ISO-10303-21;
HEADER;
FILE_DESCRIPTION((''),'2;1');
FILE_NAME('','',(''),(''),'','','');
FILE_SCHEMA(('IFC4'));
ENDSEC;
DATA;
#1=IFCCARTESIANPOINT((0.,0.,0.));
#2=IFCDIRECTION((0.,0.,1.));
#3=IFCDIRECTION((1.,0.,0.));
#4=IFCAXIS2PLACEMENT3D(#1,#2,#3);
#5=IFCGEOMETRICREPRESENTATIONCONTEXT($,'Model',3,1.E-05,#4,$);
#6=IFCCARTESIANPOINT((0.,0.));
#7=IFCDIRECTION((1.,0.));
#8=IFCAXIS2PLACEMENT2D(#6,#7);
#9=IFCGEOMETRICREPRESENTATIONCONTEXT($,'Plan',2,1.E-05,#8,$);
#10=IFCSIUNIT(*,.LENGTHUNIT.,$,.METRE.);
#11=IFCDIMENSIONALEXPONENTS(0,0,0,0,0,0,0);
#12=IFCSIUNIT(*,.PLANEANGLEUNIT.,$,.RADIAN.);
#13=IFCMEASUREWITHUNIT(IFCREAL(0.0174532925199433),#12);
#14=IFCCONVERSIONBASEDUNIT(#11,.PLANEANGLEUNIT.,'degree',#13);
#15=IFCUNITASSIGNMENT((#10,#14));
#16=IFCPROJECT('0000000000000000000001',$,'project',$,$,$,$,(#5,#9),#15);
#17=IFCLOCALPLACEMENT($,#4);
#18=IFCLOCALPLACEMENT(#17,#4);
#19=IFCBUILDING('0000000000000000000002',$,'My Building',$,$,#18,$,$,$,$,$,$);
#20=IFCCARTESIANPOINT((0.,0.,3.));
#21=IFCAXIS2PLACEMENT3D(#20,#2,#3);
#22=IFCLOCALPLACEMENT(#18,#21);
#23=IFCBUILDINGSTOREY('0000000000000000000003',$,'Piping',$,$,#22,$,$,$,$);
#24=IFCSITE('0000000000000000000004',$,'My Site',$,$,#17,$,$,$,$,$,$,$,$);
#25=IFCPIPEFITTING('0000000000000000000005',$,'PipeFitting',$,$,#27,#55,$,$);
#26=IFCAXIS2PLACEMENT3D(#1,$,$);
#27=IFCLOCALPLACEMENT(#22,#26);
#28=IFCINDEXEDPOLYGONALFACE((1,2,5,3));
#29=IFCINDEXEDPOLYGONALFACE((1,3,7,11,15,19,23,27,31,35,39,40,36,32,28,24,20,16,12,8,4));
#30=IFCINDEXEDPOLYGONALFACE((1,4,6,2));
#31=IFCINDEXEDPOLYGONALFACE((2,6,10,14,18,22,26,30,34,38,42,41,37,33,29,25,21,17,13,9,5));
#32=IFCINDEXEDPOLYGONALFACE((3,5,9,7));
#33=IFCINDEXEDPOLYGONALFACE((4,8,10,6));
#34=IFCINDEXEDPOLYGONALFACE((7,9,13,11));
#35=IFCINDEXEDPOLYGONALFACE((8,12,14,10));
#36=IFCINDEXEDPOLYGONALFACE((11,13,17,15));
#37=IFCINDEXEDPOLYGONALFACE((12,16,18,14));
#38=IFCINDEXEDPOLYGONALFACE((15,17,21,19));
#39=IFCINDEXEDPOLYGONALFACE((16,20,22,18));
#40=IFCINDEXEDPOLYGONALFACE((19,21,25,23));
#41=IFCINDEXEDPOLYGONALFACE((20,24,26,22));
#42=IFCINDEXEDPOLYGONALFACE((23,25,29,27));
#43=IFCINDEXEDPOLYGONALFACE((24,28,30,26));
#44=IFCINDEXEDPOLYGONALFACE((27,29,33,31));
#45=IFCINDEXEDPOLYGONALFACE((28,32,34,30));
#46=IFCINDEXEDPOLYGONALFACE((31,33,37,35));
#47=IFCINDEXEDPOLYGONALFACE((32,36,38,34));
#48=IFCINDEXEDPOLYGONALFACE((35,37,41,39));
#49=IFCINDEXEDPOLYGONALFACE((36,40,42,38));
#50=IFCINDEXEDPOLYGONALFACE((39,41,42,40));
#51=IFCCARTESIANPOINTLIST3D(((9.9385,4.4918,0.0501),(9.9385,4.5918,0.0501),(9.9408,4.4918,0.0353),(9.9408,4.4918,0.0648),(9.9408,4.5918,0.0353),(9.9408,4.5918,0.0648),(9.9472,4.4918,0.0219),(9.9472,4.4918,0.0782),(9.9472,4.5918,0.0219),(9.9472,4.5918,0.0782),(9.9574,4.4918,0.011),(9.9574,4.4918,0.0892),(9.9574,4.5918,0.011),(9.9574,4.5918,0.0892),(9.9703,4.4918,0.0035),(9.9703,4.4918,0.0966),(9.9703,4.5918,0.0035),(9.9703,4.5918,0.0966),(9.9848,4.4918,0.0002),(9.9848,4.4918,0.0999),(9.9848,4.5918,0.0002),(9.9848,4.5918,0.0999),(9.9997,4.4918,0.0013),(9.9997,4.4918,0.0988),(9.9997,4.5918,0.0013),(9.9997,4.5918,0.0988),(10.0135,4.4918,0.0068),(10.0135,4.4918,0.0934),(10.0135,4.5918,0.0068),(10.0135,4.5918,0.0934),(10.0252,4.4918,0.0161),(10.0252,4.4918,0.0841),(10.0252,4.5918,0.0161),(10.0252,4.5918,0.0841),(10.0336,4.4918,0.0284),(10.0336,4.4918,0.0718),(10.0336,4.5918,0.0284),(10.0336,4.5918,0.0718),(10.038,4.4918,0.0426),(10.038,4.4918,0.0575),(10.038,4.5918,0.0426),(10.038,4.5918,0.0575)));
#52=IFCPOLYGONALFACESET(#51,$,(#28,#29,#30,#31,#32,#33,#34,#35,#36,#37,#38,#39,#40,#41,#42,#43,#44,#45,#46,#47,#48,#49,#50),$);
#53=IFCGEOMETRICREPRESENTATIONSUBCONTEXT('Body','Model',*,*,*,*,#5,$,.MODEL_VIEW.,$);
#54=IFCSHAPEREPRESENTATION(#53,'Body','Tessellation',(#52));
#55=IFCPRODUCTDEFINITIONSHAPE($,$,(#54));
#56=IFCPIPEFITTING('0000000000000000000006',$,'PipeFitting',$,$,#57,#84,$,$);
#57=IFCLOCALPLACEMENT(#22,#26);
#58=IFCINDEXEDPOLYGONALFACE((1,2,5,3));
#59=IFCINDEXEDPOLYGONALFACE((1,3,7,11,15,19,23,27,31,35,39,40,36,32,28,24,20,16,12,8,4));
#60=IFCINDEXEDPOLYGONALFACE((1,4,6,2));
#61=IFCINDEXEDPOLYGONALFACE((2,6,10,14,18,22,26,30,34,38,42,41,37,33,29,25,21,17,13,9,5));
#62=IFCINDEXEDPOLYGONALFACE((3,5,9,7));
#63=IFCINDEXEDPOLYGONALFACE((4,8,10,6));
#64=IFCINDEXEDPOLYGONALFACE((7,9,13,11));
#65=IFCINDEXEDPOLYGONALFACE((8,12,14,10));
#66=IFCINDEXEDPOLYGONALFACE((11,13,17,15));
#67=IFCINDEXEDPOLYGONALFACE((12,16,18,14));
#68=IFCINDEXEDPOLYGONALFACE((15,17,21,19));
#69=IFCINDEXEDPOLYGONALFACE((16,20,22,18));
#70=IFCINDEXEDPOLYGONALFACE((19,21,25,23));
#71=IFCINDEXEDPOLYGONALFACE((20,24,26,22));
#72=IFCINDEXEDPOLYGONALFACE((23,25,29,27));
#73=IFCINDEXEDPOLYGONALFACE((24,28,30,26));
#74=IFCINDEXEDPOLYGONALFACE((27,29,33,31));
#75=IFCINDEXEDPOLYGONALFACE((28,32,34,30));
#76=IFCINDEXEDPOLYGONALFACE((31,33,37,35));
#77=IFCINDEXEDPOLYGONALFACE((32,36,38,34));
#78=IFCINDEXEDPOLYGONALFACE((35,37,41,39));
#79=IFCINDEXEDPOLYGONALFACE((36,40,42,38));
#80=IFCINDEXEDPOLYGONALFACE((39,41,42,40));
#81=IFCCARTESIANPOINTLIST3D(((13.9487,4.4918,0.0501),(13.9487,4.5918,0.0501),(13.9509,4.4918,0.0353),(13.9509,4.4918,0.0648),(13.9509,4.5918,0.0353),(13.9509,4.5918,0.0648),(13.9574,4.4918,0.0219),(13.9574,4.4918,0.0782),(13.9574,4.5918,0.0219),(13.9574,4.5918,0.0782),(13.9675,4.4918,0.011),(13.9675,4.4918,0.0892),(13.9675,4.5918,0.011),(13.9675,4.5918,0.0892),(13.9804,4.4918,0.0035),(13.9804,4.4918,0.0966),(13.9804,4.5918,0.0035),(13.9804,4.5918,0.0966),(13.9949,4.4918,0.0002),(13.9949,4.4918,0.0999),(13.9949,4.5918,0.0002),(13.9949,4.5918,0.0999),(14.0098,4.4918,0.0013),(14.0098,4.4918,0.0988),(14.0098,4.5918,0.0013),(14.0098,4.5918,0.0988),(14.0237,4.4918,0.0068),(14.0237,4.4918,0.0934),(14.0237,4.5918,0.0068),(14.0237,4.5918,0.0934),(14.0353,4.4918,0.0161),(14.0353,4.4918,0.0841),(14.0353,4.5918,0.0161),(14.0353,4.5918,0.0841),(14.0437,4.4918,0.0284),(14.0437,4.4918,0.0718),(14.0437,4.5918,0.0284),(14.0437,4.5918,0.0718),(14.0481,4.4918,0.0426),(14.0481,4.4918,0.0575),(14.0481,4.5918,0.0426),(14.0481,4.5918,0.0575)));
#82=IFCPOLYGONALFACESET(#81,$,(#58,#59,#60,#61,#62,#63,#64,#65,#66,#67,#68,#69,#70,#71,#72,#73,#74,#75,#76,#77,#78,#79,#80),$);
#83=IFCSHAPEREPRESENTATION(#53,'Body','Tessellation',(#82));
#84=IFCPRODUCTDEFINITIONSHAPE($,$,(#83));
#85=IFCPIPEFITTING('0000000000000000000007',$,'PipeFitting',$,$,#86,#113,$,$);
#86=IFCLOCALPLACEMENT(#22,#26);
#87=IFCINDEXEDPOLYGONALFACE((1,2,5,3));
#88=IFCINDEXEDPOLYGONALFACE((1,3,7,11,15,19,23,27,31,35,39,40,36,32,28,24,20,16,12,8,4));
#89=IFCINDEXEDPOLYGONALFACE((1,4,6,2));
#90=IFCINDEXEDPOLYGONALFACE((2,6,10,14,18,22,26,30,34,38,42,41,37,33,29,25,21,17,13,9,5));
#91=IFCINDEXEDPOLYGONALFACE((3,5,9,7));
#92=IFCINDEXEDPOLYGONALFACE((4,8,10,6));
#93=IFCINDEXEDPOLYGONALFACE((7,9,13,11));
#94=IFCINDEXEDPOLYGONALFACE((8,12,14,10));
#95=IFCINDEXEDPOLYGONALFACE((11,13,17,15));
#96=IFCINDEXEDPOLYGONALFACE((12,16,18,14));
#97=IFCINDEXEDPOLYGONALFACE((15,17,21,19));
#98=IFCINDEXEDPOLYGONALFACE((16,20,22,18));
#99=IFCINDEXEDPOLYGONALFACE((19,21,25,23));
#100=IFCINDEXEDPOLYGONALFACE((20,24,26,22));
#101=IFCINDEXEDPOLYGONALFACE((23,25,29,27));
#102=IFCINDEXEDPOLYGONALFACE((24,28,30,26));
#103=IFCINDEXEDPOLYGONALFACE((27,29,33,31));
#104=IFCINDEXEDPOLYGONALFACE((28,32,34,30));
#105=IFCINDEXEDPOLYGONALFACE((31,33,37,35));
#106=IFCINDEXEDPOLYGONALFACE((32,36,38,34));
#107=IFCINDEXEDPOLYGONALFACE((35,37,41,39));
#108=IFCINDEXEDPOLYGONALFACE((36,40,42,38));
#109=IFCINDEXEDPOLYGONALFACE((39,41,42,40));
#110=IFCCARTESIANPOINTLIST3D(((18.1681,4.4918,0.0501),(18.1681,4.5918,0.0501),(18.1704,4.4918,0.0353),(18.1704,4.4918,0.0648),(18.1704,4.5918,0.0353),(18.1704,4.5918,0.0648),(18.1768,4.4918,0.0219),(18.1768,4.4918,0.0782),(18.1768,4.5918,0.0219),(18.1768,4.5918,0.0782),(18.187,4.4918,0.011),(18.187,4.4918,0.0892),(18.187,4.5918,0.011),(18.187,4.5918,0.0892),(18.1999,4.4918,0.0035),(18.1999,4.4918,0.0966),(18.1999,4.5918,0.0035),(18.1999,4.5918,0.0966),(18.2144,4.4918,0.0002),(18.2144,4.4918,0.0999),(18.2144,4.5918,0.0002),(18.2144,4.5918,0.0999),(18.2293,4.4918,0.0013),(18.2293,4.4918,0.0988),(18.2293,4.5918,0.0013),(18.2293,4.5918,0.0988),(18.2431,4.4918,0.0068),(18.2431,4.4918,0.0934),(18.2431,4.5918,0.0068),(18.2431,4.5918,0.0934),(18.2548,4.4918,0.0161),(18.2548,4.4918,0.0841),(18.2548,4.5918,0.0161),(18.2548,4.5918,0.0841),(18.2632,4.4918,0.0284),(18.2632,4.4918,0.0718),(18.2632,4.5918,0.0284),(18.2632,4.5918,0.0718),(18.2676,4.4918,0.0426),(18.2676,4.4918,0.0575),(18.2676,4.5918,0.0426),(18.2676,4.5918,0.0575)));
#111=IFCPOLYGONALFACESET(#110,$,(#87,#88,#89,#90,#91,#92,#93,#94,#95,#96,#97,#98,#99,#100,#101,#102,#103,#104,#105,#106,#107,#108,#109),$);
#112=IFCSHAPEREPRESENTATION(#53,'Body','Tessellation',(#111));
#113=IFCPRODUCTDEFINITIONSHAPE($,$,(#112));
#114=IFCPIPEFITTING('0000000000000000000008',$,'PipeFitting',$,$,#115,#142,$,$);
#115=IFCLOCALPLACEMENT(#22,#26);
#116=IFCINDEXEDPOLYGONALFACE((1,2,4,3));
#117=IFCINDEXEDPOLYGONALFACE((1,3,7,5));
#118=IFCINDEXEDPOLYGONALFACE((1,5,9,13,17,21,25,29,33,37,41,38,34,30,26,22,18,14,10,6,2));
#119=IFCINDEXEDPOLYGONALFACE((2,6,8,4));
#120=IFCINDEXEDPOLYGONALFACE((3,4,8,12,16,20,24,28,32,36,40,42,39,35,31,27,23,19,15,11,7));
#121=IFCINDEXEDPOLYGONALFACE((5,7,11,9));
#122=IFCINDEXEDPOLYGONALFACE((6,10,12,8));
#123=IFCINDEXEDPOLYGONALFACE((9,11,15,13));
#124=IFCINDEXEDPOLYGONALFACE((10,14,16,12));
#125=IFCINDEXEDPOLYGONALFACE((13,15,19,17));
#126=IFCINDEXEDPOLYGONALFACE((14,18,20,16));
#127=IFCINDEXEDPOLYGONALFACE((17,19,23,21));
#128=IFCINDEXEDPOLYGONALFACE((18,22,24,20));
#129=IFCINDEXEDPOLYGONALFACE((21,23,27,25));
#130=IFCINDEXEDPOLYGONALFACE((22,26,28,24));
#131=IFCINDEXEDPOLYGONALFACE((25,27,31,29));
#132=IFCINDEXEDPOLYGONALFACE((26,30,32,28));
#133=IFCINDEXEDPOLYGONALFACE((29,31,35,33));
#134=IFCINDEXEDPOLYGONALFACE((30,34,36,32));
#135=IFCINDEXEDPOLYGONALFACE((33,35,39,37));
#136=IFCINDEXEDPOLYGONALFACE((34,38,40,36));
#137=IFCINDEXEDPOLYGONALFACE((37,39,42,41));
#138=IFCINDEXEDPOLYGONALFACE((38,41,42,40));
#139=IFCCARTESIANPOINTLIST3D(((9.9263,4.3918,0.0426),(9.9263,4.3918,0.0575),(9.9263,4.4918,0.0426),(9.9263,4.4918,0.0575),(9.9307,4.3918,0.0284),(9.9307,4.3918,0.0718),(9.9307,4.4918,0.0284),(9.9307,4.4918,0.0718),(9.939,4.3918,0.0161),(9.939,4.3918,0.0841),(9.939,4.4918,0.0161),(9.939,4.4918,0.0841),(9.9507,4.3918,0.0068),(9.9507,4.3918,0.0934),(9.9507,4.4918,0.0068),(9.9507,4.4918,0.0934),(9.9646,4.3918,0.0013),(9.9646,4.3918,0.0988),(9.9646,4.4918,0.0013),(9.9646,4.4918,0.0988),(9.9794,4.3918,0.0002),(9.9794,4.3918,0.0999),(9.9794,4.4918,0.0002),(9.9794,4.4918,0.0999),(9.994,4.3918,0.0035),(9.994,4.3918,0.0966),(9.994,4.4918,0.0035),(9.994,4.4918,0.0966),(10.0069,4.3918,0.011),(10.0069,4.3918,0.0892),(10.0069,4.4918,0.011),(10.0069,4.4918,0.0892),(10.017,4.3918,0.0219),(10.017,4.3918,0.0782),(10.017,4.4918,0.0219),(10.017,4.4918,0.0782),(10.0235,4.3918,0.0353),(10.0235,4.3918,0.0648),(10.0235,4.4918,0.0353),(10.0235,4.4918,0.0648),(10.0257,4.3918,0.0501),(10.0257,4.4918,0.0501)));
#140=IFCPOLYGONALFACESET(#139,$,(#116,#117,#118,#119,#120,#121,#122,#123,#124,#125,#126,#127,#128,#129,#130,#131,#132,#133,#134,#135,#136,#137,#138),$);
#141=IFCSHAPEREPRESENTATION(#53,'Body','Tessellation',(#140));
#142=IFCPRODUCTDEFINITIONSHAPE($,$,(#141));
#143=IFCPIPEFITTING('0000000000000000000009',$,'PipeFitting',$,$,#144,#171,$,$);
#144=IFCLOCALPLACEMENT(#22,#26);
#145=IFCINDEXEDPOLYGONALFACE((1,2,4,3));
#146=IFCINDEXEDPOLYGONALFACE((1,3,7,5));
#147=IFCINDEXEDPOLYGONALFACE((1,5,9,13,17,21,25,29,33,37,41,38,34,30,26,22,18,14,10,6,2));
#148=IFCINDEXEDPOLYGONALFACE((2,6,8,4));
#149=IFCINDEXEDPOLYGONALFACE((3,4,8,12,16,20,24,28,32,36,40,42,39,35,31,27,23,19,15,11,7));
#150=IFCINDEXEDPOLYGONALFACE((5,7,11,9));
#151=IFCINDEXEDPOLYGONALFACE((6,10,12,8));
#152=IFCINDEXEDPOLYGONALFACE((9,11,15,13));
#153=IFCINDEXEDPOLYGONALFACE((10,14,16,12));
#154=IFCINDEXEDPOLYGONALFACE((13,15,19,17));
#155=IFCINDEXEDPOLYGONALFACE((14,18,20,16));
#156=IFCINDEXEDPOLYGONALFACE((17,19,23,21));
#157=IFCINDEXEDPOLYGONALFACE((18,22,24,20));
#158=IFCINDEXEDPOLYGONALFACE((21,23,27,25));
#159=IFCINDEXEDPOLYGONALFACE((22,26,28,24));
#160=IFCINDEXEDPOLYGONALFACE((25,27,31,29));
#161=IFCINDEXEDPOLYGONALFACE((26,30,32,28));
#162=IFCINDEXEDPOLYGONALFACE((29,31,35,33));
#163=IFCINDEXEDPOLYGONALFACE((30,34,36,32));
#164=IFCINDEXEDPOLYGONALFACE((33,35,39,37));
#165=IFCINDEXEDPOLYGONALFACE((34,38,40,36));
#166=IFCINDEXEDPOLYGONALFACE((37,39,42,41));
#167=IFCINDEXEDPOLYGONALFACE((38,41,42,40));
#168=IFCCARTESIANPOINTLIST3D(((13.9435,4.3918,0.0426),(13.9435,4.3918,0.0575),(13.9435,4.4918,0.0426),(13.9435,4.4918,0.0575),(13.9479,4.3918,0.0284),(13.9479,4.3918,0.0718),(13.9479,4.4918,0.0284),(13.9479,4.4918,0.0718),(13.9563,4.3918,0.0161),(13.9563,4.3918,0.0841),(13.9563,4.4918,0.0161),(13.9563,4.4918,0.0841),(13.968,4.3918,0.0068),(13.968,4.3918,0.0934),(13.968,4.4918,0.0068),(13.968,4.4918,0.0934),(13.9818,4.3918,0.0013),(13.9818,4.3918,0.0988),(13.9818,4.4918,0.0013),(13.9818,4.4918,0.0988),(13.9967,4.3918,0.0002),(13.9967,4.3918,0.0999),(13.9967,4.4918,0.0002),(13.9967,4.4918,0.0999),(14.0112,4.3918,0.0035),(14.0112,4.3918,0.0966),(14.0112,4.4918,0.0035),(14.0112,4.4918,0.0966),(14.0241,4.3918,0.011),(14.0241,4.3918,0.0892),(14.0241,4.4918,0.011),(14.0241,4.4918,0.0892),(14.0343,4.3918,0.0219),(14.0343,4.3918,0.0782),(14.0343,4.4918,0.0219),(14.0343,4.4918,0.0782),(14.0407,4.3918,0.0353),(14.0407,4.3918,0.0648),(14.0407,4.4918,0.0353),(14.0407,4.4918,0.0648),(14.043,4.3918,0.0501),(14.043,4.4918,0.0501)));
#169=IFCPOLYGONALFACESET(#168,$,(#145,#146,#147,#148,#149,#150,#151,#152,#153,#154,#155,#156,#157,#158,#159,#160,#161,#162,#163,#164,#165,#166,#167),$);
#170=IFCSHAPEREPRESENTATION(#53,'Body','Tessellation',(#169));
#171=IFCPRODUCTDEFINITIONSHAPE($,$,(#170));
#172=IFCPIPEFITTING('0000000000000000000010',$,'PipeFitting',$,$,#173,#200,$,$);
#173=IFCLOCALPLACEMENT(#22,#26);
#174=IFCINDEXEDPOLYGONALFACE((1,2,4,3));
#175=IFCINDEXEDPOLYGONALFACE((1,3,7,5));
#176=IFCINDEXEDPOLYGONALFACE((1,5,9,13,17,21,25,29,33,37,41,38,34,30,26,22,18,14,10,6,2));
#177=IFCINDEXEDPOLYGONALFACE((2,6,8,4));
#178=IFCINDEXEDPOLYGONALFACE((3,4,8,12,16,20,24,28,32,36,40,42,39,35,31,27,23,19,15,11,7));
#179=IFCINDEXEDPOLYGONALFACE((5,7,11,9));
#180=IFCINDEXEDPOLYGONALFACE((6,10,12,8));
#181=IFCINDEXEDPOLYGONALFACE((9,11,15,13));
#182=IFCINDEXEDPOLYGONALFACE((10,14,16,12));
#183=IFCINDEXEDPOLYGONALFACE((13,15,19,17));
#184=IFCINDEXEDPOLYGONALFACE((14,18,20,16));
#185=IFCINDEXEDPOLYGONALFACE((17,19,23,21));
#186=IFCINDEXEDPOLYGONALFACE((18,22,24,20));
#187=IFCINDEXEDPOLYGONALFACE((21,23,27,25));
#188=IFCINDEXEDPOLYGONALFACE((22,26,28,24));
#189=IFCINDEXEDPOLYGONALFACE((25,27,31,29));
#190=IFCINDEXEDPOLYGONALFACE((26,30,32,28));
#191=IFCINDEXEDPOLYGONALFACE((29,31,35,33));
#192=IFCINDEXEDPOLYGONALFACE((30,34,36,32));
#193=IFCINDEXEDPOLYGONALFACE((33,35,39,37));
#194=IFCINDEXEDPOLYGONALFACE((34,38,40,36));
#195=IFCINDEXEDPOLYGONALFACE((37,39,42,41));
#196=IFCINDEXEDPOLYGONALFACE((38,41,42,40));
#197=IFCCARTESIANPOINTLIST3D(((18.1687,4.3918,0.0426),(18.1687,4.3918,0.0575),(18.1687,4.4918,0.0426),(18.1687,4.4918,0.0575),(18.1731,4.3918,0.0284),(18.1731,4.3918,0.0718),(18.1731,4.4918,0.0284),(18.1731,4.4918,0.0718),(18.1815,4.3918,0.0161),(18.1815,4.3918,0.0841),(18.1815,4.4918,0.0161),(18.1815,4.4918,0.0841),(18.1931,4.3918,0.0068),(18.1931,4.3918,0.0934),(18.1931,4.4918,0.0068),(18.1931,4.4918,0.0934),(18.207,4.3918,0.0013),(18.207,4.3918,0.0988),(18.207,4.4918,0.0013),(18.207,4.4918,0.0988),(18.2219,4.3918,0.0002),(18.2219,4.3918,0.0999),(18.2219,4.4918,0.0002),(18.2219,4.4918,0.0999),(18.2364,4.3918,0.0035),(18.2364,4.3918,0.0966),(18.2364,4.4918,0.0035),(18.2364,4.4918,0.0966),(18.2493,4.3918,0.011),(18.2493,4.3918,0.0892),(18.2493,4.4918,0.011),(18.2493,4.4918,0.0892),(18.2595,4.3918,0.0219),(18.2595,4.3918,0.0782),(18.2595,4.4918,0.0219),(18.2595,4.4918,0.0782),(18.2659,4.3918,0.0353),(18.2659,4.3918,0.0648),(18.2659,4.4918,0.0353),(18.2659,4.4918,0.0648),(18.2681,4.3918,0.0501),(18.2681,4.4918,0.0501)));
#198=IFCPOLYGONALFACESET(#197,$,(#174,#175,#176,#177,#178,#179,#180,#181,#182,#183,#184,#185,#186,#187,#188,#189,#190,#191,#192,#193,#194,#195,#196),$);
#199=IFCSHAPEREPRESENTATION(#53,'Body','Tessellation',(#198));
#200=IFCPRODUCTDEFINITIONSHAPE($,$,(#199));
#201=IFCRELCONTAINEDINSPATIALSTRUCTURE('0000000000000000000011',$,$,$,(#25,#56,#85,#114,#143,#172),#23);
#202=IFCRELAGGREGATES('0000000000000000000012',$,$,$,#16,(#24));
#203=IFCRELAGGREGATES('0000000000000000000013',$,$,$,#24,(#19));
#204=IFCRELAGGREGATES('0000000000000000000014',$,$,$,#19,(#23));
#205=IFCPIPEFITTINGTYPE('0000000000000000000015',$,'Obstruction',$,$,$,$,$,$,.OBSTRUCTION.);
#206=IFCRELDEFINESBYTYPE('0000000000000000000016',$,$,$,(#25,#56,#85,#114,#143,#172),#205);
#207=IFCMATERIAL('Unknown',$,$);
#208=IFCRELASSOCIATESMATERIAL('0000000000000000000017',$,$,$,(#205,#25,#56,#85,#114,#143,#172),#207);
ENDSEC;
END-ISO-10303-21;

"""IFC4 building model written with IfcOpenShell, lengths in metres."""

from ifc_helpers import new_model, entity, si_unit, converted_unit, frame, origin_with_axes, origin_2d_with_axis, place, context, subcontext, project, spatial, circle, extrude, material, material_profile, profile_set, profile_usage, type_object, element, save


model = new_model("IFC4")

# Units and contexts
model_context = context("Model", 3, precision=1e-05, world=origin_with_axes())
plan_context = context("Plan", 2, precision=1e-05, world=origin_2d_with_axis())
body_context = subcontext(model_context, "Body", "Model", "MODEL_VIEW")
ifc_project = project(units=[si_unit("LENGTHUNIT", "METRE"), converted_unit("PLANEANGLEUNIT", "degree", entity("IfcReal", 0.0174532925199433), si_unit("PLANEANGLEUNIT", "RADIAN"), dimensions=[0, 0, 0, 0, 0, 0, 0])], contexts=[model_context, plan_context])

# Site, building, storey
site_placement = place(None, origin_with_axes())
site = spatial("IfcSite", under=ifc_project, at=site_placement, Name="My Site")
building_placement = place(site_placement, origin_with_axes())
building = spatial("IfcBuilding", under=site, at=building_placement, Name="My Building")
storey_placement = place(building_placement, frame((0.0, 0.0, 3.0), z_axis=(0.0, 0.0, 1.0), x_axis=(1.0, 0.0, 0.0)))
storey = spatial("IfcBuildingStorey", under=building, at=storey_placement, Name="Piping")

# Shared definitions
ifc_material = material(Name="Unknown")

# Pipe fittings
ifc_material_profile_1 = material_profile(ifc_material, circle(Radius=0.05))
ifc_profile_set_1 = profile_set([ifc_material_profile_1])
ifc_profile_usage_1 = profile_usage(ifc_profile_set_1, cardinal=15)
pipe_fitting_type_1 = type_object("IfcPipeFittingType", Name="Obstruction", PredefinedType="OBSTRUCTION", material=ifc_profile_set_1)
pipe_fitting_1_placement = place(storey_placement, frame((9.9885, 4.4918, 0.0501), z_axis=(0.0, 1.0, 0.0), x_axis=(-1.0, 0.0, 0.0)))
element("IfcPipeFitting", 1, at=pipe_fitting_1_placement, inside=storey, type_object=pipe_fitting_type_1, material=ifc_profile_usage_1, Name="PipeFitting", context=body_context, shape_type="SweptSolid", body=[
    extrude(circle(Radius=0.05), origin_with_axes(), (0.0, 0.0, 1.0), 0.1),
])
ifc_profile_usage_2 = profile_usage(ifc_profile_set_1, cardinal=15)
pipe_fitting_2_placement = place(storey_placement, frame((13.9987, 4.4918, 0.0501), z_axis=(0.0, 1.0, 0.0), x_axis=(-1.0, 0.0, 0.0)))
element("IfcPipeFitting", 2, at=pipe_fitting_2_placement, inside=storey, type_object=pipe_fitting_type_1, material=ifc_profile_usage_2, Name="PipeFitting", context=body_context, shape_type="SweptSolid", body=[
    extrude(circle(Radius=0.05), origin_with_axes(), (0.0, 0.0, 1.0), 0.1),
])
ifc_profile_usage_3 = profile_usage(ifc_profile_set_1, cardinal=15)
pipe_fitting_3_placement = place(storey_placement, frame((18.2181, 4.4918, 0.0501), z_axis=(0.0, 1.0, 0.0), x_axis=(-1.0, 0.0, 0.0)))
element("IfcPipeFitting", 3, at=pipe_fitting_3_placement, inside=storey, type_object=pipe_fitting_type_1, material=ifc_profile_usage_3, Name="PipeFitting", context=body_context, shape_type="SweptSolid", body=[
    extrude(circle(Radius=0.05), origin_with_axes(), (0.0, 0.0, 1.0), 0.1),
])
ifc_profile_usage_4 = profile_usage(ifc_profile_set_1, cardinal=15)
pipe_fitting_4_placement = place(storey_placement, frame((9.9757, 4.4918, 0.0501), z_axis=(0.0, -1.0, 0.0), x_axis=(1.0, 0.0, 0.0)))
element("IfcPipeFitting", 4, at=pipe_fitting_4_placement, inside=storey, type_object=pipe_fitting_type_1, material=ifc_profile_usage_4, Name="PipeFitting", context=body_context, shape_type="SweptSolid", body=[
    extrude(circle(Radius=0.05), origin_with_axes(), (0.0, 0.0, 1.0), 0.1),
])
ifc_profile_usage_5 = profile_usage(ifc_profile_set_1, cardinal=15)
pipe_fitting_5_placement = place(storey_placement, frame((13.993, 4.4918, 0.0501), z_axis=(0.0, -1.0, 0.0), x_axis=(1.0, 0.0, 0.0)))
element("IfcPipeFitting", 5, at=pipe_fitting_5_placement, inside=storey, type_object=pipe_fitting_type_1, material=ifc_profile_usage_5, Name="PipeFitting", context=body_context, shape_type="SweptSolid", body=[
    extrude(circle(Radius=0.05), origin_with_axes(), (0.0, 0.0, 1.0), 0.1),
])
ifc_profile_usage_6 = profile_usage(ifc_profile_set_1, cardinal=15)
pipe_fitting_6_placement = place(storey_placement, frame((18.2181, 4.4918, 0.0501), z_axis=(0.0, -1.0, 0.0), x_axis=(1.0, 0.0, 0.0)))
element("IfcPipeFitting", 6, at=pipe_fitting_6_placement, inside=storey, type_object=pipe_fitting_type_1, material=ifc_profile_usage_6, Name="PipeFitting", context=body_context, shape_type="SweptSolid", body=[
    extrude(circle(Radius=0.05), origin_with_axes(), (0.0, 0.0, 1.0), 0.1),
])

save(model, "model.ifc")
